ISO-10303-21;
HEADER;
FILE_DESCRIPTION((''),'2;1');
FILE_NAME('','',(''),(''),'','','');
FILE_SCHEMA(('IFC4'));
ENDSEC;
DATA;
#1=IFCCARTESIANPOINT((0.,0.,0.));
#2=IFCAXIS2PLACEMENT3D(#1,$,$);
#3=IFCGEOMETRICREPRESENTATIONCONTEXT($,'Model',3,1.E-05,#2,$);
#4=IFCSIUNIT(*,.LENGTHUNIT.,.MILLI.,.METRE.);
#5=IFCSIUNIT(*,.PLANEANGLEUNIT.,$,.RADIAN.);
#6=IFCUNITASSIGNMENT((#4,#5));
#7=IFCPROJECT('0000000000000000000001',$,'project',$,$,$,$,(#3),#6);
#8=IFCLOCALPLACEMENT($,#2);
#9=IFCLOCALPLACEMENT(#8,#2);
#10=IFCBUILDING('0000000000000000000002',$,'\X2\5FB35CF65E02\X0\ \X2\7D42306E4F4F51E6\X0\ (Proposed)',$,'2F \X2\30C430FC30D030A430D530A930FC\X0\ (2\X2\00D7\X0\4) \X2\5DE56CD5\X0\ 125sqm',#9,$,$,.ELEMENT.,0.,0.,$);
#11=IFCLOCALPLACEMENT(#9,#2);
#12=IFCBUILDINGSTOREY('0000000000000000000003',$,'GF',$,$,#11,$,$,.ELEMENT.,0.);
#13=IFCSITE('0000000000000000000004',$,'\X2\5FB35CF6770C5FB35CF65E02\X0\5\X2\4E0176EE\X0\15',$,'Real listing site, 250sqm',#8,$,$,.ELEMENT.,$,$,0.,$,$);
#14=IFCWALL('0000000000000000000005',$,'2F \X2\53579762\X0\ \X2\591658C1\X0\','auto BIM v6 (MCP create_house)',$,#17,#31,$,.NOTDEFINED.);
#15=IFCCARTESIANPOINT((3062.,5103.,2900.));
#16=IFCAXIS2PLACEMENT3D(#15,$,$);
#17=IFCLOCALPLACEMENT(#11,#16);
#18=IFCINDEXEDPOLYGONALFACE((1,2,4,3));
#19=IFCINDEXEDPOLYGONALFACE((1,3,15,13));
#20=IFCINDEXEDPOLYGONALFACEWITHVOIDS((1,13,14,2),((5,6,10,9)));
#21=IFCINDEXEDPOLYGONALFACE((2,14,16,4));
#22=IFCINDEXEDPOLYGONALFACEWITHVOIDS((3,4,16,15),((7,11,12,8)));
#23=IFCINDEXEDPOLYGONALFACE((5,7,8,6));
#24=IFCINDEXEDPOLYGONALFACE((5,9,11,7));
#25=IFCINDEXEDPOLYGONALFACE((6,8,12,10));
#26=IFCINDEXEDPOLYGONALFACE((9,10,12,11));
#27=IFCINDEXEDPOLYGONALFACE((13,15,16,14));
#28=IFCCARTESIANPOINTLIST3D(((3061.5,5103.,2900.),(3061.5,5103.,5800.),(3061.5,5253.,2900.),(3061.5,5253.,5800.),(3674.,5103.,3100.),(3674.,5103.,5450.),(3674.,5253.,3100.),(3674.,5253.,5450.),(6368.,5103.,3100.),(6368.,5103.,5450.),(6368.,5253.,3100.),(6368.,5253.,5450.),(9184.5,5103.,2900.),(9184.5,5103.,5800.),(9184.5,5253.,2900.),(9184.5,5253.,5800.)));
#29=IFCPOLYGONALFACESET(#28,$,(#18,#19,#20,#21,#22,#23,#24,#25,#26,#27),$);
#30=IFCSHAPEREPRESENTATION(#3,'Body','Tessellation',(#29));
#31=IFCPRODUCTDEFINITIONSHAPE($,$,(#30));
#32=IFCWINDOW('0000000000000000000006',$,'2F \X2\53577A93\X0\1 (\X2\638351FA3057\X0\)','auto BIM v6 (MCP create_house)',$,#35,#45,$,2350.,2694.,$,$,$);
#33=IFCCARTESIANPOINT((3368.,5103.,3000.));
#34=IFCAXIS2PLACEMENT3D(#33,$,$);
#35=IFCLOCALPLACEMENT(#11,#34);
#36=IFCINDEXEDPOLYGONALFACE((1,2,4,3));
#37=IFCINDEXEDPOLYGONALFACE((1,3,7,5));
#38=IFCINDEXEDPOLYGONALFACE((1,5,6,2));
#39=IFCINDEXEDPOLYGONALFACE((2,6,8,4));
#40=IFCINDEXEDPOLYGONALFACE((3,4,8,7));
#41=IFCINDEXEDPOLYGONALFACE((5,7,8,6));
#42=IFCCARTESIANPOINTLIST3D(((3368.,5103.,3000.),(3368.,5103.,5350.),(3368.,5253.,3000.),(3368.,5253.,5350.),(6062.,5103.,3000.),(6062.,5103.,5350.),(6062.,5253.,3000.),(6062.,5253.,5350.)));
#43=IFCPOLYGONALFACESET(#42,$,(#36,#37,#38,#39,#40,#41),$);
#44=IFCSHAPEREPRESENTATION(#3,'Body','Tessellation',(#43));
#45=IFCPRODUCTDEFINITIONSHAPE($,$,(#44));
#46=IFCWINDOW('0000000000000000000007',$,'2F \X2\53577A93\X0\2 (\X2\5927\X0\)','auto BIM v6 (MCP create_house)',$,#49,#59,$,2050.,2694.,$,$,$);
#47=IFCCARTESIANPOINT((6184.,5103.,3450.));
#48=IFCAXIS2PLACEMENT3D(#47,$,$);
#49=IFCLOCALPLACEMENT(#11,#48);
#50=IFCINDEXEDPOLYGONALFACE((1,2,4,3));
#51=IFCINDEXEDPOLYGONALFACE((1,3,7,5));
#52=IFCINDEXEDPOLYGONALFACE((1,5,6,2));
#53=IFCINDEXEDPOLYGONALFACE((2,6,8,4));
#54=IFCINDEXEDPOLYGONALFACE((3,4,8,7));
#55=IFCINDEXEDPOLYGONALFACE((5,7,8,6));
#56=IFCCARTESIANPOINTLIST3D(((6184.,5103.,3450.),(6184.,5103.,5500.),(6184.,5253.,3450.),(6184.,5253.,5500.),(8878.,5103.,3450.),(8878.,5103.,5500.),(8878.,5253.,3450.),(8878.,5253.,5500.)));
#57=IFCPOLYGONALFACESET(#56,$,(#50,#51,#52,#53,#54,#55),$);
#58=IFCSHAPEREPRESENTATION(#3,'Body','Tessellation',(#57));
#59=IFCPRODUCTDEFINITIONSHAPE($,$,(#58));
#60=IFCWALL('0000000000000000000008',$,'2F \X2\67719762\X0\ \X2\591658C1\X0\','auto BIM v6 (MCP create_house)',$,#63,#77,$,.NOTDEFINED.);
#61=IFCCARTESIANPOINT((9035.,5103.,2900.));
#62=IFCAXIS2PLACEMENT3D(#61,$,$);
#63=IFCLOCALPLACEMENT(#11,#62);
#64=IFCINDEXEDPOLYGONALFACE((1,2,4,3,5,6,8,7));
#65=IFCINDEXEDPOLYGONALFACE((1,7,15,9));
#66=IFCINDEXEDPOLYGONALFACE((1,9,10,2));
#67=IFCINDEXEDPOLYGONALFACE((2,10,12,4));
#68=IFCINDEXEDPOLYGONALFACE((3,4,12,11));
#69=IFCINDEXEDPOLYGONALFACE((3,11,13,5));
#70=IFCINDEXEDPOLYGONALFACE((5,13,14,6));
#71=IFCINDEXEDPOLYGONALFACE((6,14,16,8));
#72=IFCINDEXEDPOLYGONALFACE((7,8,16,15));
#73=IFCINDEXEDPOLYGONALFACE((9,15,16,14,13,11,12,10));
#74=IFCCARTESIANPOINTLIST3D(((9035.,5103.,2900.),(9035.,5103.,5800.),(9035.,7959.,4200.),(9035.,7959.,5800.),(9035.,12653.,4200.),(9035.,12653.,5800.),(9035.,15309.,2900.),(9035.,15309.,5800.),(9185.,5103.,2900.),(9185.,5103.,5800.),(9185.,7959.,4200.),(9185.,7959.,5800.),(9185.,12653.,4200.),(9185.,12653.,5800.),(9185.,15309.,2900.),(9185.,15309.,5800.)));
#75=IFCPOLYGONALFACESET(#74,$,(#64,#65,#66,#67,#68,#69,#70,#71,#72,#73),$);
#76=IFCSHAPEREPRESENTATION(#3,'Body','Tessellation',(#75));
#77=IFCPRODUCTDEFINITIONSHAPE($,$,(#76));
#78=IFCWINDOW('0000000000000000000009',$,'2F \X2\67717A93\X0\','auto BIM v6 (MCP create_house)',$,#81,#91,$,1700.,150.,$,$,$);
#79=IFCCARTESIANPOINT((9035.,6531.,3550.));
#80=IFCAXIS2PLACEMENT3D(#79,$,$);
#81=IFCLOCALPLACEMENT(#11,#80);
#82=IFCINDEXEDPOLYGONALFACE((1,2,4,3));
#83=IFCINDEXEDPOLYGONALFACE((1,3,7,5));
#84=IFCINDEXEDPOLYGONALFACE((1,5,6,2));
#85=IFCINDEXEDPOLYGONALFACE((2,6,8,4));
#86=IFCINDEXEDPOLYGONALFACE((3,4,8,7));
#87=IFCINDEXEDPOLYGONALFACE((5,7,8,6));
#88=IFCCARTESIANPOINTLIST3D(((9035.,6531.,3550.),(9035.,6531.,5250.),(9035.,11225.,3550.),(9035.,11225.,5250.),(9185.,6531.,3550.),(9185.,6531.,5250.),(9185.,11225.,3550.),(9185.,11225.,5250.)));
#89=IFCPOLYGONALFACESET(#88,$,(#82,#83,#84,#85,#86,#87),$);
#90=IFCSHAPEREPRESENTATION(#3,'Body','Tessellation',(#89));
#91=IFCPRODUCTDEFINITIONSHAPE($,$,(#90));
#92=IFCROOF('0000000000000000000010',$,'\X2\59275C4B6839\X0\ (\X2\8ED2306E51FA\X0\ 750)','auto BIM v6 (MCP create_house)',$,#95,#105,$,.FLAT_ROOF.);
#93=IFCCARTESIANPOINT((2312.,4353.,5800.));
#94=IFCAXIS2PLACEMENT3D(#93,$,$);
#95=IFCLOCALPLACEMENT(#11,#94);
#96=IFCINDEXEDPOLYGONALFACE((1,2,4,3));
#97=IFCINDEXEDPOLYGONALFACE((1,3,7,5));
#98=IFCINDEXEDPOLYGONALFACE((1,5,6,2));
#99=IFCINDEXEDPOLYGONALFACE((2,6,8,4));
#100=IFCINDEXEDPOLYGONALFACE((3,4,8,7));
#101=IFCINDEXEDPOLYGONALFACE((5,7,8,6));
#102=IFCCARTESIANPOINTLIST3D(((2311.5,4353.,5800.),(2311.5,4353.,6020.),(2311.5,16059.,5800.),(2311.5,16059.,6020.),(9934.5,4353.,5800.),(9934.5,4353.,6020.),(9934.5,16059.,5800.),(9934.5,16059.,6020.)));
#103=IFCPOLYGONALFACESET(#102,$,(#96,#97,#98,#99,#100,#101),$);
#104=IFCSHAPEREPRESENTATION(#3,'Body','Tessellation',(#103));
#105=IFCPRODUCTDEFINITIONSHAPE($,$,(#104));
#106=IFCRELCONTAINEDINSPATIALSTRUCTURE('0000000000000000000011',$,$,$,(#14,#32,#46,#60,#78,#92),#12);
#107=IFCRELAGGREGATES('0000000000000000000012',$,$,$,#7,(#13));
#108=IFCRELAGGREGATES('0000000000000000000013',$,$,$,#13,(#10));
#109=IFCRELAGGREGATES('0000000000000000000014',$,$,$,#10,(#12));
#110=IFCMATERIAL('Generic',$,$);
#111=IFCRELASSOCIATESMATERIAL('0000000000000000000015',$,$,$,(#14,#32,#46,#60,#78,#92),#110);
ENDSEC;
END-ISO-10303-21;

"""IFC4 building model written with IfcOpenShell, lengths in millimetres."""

from ifc_helpers import new_model, si_unit, frame, frame_2d, origin, place, context, project, spatial, rectangle, extrude, material, element, fill, save


model = new_model("IFC4")

# Units and contexts
model_context = context("Model", 3, precision=1e-05, world=origin())
ifc_project = project(units=[si_unit("LENGTHUNIT", "METRE", prefix="MILLI"), si_unit("PLANEANGLEUNIT", "RADIAN")], contexts=[model_context])

# Site, building, storey
site_placement = place(None, origin())
site = spatial("IfcSite", under=ifc_project, at=site_placement, Name="徳島県徳島市5丁目15", ObjectType="Real listing site, 250sqm", CompositionType="ELEMENT", RefElevation=0.0)
building_placement = place(site_placement, origin())
building = spatial("IfcBuilding", under=site, at=building_placement, Name="徳島市 終の住処 (Proposed)", ObjectType="2F ツーバイフォー (2×4) 工法 125sqm", CompositionType="ELEMENT", ElevationOfRefHeight=0.0, ElevationOfTerrain=0.0)
storey_placement = place(building_placement, origin())
storey = spatial("IfcBuildingStorey", under=building, at=storey_placement, Name="GF", CompositionType="ELEMENT", Elevation=0.0)

# Shared definitions
ifc_material = material(Name="Generic")

# Wall, openings, windows
wall_1_placement = place(storey_placement, frame((3062.0, 5103.0, 2900.0)))
wall_1 = element("IfcWall", 1, at=wall_1_placement, inside=storey, material=ifc_material, Name="2F 南面 外壁", Description="auto BIM v6 (MCP create_house)", PredefinedType="NOTDEFINED", context=model_context, shape_type="SweptSolid", body=[
    extrude(rectangle(XDim=6123.0, YDim=150.0, at=frame_2d((3061.0, 75.0))), frame((3062.0, 5103.0, 2900.0)), (0.0, 0.0, 1.0), 2900.0),
])
opening_1_placement = place(storey_placement, frame((3368.0, 5103.0, 3000.0)))
opening_1 = element("IfcOpeningElement", 2, at=opening_1_placement, cuts=wall_1, PredefinedType="NOTDEFINED", context=model_context, shape_type="SweptSolid", body=[
    extrude(rectangle(XDim=2694.0, YDim=150.0, at=frame_2d((1347.0, 75.0))), frame((3368.0, 5103.0, 3000.0)), (0.0, 0.0, 1.0), 2350.0),
])
opening_2_placement = place(storey_placement, frame((6184.0, 5103.0, 3450.0)))
opening_2 = element("IfcOpeningElement", 3, at=opening_2_placement, cuts=wall_1, PredefinedType="NOTDEFINED", context=model_context, shape_type="SweptSolid", body=[
    extrude(rectangle(XDim=2694.0, YDim=150.0, at=frame_2d((1347.0, 75.0))), frame((6184.0, 5103.0, 3450.0)), (0.0, 0.0, 1.0), 2050.0),
])
window_1_placement = place(storey_placement, frame((3368.0, 5103.0, 3000.0)))
window_1 = element("IfcWindow", 4, at=window_1_placement, inside=storey, material=ifc_material, Name="2F 南窓1 (掃出し)", Description="auto BIM v6 (MCP create_house)", OverallHeight=2350.0, OverallWidth=2694.0, context=model_context, shape_type="SweptSolid", body=[
    extrude(rectangle(XDim=2694.0, YDim=150.0, at=frame_2d((1347.0, 75.0))), frame((3368.0, 5103.0, 3000.0)), (0.0, 0.0, 1.0), 2350.0),
])
fill(opening_1, window_1)
window_2_placement = place(storey_placement, frame((6184.0, 5103.0, 3450.0)))
window_2 = element("IfcWindow", 5, at=window_2_placement, inside=storey, material=ifc_material, Name="2F 南窓2 (大)", Description="auto BIM v6 (MCP create_house)", OverallHeight=2050.0, OverallWidth=2694.0, context=model_context, shape_type="SweptSolid", body=[
    extrude(rectangle(XDim=2694.0, YDim=150.0, at=frame_2d((1347.0, 75.0))), frame((6184.0, 5103.0, 3450.0)), (0.0, 0.0, 1.0), 2050.0),
])
fill(opening_2, window_2)

# Wall, opening, window
wall_2_placement = place(storey_placement, frame((9035.0, 5103.0, 2900.0)))
wall_2 = element("IfcWall", 6, at=wall_2_placement, inside=storey, material=ifc_material, Name="2F 東面 外壁", Description="auto BIM v6 (MCP create_house)", PredefinedType="NOTDEFINED", context=model_context, shape_type="SweptSolid", body=[
    extrude(rectangle(XDim=150.0, YDim=10206.0, at=frame_2d((75.0, 5103.0))), frame((9035.0, 5103.0, 2900.0)), (0.0, 0.0, 1.0), 2900.0),
])
opening_3_placement = place(storey_placement, frame((9035.0, 6531.0, 3550.0)))
opening_3 = element("IfcOpeningElement", 7, at=opening_3_placement, cuts=wall_2, PredefinedType="NOTDEFINED", context=model_context, shape_type="SweptSolid", body=[
    extrude(rectangle(XDim=150.0, YDim=4694.0, at=frame_2d((75.0, 2347.0))), frame((9035.0, 6531.0, 3550.0)), (0.0, 0.0, 1.0), 1700.0),
])
window_3_placement = place(storey_placement, frame((9035.0, 6531.0, 3550.0)))
window_3 = element("IfcWindow", 8, at=window_3_placement, inside=storey, material=ifc_material, Name="2F 東窓", Description="auto BIM v6 (MCP create_house)", OverallHeight=1700.0, OverallWidth=150.0, context=model_context, shape_type="SweptSolid", body=[
    extrude(rectangle(XDim=150.0, YDim=4694.0, at=frame_2d((75.0, 2347.0))), frame((9035.0, 6531.0, 3550.0)), (0.0, 0.0, 1.0), 1700.0),
])
fill(opening_3, window_3)

# Roof
roof_placement = place(storey_placement, frame((2312.0, 4353.0, 5800.0)))
element("IfcRoof", 9, at=roof_placement, inside=storey, material=ifc_material, Name="大屋根 (軒の出 750)", Description="auto BIM v6 (MCP create_house)", PredefinedType="FLAT_ROOF", context=model_context, shape_type="SweptSolid", body=[
    extrude(rectangle(XDim=7623.0, YDim=11706.0, at=frame_2d((3811.0, 5853.0))), frame((2312.0, 4353.0, 5800.0)), (0.0, 0.0, 1.0), 220.0),
])

save(model, "model.ifc")
